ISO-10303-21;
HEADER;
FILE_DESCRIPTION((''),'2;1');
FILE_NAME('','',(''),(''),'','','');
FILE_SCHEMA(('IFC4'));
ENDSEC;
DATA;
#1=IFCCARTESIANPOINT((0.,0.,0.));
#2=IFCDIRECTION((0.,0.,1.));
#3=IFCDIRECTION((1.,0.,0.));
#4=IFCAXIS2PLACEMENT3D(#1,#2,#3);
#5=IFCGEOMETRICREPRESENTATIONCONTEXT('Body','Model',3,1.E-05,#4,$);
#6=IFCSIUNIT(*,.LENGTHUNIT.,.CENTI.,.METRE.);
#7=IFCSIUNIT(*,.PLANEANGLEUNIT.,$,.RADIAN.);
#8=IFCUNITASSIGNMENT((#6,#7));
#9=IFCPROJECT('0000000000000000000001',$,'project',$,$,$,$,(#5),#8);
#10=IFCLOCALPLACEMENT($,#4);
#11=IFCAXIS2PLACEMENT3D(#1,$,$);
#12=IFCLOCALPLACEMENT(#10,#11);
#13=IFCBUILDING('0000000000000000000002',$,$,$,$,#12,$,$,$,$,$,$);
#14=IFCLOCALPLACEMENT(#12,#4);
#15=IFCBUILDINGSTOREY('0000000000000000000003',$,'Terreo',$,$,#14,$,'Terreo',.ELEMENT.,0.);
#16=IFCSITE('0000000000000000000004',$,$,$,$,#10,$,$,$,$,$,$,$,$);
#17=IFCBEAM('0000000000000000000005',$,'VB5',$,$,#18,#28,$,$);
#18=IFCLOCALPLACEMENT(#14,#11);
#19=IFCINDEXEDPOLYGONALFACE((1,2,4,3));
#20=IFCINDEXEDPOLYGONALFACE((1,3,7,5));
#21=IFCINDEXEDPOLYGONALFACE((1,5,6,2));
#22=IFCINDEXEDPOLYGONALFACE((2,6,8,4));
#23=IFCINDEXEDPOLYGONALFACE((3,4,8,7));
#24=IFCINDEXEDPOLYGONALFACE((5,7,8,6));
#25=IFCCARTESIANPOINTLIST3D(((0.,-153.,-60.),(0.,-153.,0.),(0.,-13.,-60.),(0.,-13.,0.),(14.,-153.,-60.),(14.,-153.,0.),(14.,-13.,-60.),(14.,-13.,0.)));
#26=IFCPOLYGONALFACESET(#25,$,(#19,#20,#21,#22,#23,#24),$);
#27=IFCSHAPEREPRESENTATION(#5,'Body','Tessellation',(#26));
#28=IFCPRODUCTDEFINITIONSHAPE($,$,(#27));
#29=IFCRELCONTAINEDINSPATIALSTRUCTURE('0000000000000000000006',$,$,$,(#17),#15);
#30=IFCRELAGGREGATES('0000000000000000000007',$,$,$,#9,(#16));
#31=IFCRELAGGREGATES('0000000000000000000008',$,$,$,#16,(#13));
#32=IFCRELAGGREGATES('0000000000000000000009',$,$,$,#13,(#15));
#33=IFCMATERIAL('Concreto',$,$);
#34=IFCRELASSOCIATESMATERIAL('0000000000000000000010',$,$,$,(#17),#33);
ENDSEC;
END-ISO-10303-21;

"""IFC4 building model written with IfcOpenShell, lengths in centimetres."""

from ifc_helpers import new_model, si_unit, frame, origin, origin_with_axes, origin_2d_with_axis, place, context, project, spatial, rectangle, extrude, material, element, save


model = new_model("IFC4")

# Units and contexts
model_context = context("Model", 3, precision=1e-05, world=origin_with_axes(), identifier="Body")
ifc_project = project(units=[si_unit("LENGTHUNIT", "METRE", prefix="CENTI"), si_unit("PLANEANGLEUNIT", "RADIAN")], contexts=[model_context])

# Site, building, storey
site_placement = place(None, origin_with_axes())
site = spatial("IfcSite", under=ifc_project, at=site_placement)
building_placement = place(site_placement, origin())
building = spatial("IfcBuilding", under=site, at=building_placement)
storey_placement = place(building_placement, origin_with_axes())
storey = spatial("IfcBuildingStorey", under=building, at=storey_placement, Name="Terreo", LongName="Terreo", CompositionType="ELEMENT", Elevation=0.0)

# Shared definitions
ifc_material = material(Name="Concreto")

# Beam
beam_1_placement = place(storey_placement, frame((7.0, -83.0, 0.0), z_axis=(0.0, 0.0, 1.0), x_axis=(1.0, 0.0, 0.0)))
element("IfcBeam", 1, at=beam_1_placement, inside=storey, material=ifc_material, Name="VB5", context=model_context, shape_type="SolidModel", body=[
    extrude(rectangle(XDim=14.0, YDim=60.0, at=origin_2d_with_axis()), frame((0.0, -70.0, -30.0), z_axis=(0.0, 1.0, 0.0), x_axis=(1.0, 0.0, 0.0)), (0.0, 0.0, 1.0), 140.0),
])

save(model, "model.ifc")
